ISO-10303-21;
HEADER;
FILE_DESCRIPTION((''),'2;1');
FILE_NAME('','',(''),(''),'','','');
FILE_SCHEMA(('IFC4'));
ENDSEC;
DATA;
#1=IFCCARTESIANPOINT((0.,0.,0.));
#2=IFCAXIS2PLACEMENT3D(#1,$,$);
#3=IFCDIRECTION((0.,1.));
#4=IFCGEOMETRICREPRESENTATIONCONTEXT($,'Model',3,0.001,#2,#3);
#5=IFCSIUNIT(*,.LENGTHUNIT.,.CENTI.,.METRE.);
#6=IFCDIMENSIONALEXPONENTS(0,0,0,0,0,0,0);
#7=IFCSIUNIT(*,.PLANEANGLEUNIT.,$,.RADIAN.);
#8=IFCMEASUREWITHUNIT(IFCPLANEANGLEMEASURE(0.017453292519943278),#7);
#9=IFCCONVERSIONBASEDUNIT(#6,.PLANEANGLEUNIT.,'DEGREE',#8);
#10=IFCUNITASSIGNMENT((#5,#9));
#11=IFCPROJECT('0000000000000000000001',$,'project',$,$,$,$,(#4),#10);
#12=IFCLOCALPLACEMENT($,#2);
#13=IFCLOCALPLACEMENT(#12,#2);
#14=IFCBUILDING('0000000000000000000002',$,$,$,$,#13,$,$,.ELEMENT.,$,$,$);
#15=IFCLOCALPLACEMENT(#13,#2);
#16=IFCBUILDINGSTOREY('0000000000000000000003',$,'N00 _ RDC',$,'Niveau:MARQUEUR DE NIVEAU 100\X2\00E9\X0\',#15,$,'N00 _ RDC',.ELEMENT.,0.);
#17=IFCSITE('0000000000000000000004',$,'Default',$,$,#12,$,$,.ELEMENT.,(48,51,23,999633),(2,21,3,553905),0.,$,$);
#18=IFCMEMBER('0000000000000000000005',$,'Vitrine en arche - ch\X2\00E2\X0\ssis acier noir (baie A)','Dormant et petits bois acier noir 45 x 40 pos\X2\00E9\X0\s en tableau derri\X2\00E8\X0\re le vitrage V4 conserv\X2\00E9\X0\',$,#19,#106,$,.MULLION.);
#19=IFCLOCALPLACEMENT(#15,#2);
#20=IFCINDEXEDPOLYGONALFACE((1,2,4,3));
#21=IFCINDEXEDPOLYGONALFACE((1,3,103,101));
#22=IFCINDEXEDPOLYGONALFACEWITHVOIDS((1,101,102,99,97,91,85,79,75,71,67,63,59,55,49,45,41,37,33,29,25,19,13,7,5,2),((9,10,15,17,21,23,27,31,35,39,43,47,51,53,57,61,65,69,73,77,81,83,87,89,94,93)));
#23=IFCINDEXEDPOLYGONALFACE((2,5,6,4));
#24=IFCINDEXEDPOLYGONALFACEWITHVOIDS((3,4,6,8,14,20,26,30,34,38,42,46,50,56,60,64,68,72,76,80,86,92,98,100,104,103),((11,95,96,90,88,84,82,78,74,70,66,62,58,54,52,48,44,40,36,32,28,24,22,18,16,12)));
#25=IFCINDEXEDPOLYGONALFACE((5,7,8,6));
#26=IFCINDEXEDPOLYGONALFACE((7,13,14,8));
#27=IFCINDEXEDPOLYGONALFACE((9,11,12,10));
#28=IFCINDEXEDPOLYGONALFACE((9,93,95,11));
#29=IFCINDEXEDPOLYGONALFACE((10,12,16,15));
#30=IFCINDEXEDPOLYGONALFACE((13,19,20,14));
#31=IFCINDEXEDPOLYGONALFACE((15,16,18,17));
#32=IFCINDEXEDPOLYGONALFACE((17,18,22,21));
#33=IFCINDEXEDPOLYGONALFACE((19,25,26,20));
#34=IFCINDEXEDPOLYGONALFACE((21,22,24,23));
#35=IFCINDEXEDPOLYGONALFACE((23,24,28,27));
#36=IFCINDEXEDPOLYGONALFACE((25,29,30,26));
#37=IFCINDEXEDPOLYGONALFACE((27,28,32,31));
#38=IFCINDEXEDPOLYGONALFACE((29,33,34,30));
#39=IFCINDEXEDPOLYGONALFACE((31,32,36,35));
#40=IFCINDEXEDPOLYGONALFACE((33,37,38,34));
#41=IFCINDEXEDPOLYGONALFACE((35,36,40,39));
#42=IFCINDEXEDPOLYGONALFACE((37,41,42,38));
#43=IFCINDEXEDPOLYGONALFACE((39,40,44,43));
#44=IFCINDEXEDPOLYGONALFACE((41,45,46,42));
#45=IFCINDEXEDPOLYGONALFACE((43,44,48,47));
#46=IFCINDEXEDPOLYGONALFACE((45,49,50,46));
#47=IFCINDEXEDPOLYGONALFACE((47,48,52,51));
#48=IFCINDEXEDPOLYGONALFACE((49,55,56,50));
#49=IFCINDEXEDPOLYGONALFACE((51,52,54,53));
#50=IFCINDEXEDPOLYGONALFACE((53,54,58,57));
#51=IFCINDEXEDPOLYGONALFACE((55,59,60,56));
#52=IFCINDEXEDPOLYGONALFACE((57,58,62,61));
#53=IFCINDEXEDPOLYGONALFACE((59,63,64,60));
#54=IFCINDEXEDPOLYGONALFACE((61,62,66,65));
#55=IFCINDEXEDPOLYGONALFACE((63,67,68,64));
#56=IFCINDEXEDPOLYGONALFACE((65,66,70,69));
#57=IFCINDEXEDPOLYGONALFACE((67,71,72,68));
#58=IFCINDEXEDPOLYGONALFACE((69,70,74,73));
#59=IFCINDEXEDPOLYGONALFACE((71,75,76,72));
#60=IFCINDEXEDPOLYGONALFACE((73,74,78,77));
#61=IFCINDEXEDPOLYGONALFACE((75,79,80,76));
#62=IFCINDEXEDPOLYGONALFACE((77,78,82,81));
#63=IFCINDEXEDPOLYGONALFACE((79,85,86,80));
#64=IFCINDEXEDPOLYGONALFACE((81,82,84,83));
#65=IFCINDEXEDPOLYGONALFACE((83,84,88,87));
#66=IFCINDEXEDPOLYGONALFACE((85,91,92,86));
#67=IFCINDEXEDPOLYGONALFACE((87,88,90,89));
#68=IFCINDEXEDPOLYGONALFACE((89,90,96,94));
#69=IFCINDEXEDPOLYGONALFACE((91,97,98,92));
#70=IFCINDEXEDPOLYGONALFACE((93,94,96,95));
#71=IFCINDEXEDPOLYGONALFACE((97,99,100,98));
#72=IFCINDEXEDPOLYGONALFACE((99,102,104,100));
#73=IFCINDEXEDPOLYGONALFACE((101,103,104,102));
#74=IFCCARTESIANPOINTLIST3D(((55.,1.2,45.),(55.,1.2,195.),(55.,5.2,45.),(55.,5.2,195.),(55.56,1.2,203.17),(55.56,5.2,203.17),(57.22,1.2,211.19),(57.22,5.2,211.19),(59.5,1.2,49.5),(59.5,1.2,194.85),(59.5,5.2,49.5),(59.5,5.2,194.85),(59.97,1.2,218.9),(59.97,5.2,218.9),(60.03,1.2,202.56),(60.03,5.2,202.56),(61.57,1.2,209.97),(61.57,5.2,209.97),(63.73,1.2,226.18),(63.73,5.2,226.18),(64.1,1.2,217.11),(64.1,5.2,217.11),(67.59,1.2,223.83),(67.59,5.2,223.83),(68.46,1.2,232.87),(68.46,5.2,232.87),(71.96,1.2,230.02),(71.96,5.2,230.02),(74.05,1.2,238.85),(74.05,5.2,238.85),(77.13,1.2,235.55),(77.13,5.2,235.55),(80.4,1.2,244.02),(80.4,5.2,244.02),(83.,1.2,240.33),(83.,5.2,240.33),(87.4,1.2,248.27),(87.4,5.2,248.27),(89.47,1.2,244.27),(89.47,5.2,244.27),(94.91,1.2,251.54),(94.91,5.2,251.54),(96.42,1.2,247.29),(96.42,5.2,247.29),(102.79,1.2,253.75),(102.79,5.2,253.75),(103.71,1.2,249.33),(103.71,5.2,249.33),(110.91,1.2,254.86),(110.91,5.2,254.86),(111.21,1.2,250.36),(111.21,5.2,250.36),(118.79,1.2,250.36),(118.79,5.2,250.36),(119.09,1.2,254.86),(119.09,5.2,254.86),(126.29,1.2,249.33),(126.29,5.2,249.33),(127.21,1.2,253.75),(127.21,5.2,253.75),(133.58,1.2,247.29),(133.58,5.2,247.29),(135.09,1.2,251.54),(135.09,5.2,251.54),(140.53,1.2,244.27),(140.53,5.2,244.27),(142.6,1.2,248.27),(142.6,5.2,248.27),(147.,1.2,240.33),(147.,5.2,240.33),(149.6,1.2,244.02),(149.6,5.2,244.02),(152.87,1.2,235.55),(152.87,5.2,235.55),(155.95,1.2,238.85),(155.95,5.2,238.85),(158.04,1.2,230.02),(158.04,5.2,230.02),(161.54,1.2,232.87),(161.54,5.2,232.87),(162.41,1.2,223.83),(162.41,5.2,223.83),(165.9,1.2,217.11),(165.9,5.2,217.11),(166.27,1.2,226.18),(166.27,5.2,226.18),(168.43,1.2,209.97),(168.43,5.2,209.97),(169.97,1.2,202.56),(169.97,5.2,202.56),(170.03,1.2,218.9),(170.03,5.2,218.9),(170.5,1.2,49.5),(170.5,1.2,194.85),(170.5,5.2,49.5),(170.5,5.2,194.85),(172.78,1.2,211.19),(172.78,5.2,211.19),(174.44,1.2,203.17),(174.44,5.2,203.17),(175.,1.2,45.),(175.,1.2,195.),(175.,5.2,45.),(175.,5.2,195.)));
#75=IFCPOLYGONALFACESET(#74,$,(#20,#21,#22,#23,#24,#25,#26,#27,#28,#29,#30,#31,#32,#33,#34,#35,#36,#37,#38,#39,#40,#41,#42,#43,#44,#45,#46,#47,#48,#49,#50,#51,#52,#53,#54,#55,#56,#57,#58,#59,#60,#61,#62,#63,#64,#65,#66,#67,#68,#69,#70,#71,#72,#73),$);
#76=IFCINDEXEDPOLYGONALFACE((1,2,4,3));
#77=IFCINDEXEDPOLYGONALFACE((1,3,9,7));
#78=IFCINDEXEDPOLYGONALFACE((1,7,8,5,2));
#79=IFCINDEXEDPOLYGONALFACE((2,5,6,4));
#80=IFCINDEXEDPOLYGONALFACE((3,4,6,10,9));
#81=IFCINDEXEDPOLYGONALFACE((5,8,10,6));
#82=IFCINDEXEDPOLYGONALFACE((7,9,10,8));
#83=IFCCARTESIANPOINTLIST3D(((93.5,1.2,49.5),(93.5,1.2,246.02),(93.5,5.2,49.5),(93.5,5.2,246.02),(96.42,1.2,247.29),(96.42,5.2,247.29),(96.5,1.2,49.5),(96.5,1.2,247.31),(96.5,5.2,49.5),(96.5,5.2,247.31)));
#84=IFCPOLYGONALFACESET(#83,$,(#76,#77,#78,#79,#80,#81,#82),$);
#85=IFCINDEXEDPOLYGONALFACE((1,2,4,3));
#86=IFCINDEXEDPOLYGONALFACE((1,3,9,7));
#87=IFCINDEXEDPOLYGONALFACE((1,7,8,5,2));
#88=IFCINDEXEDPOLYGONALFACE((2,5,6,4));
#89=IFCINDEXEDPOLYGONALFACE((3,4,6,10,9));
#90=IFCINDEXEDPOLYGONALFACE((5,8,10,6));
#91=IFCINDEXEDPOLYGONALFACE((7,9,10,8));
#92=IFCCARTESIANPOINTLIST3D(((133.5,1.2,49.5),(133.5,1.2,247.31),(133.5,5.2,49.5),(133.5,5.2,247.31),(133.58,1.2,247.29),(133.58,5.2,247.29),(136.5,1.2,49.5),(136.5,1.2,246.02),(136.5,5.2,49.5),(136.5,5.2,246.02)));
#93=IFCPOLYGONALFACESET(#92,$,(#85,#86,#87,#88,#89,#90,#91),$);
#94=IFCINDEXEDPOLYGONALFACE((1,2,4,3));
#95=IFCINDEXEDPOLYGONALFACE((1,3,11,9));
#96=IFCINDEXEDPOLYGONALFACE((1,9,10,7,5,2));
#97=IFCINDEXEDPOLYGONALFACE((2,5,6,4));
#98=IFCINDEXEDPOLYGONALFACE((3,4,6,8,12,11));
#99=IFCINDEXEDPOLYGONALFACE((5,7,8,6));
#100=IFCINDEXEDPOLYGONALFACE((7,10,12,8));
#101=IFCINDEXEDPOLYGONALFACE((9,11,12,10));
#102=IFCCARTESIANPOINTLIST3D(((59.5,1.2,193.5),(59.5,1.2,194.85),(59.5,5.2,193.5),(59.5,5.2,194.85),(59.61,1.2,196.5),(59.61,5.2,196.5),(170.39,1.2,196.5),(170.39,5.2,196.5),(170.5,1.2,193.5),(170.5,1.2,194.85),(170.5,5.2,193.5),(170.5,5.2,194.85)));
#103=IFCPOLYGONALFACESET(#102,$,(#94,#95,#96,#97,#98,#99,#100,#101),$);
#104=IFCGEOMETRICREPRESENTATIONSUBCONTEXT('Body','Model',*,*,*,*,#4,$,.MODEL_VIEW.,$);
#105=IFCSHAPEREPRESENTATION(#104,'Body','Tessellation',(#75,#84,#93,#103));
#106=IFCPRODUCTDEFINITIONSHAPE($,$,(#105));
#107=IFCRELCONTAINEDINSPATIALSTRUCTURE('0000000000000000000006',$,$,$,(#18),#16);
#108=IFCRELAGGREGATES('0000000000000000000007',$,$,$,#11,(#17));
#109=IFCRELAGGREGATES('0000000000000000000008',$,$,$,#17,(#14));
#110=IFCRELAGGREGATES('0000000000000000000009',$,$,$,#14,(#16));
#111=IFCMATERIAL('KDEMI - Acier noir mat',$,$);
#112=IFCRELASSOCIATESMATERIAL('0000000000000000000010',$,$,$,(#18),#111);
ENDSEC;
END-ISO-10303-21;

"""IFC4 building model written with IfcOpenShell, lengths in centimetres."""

from ifc_helpers import new_model, entity, si_unit, converted_unit, direction, frame, origin, origin_with_axes, place, context, subcontext, project, spatial, polyline, outline, extrude, material, element, save


model = new_model("IFC4")

# Units and contexts
model_context = context("Model", 3, precision=0.001, world=origin(), true_north=direction((0.0, 1.0)))
body_context = subcontext(model_context, "Body", "Model", "MODEL_VIEW")
ifc_project = project(units=[si_unit("LENGTHUNIT", "METRE", prefix="CENTI"), converted_unit("PLANEANGLEUNIT", "DEGREE", entity("IfcPlaneAngleMeasure", 0.017453292519943278), si_unit("PLANEANGLEUNIT", "RADIAN"), dimensions=[0, 0, 0, 0, 0, 0, 0])], contexts=[model_context])

# Site, building, storey
site_placement = place(None, origin())
site = spatial("IfcSite", under=ifc_project, at=site_placement, Name="Default", CompositionType="ELEMENT", RefLatitude=(48, 51, 23, 999633), RefLongitude=(2, 21, 3, 553905), RefElevation=0.0)
building_placement = place(site_placement, origin())
building = spatial("IfcBuilding", under=site, at=building_placement, CompositionType="ELEMENT")
storey_placement = place(building_placement, origin())
storey = spatial("IfcBuildingStorey", under=building, at=storey_placement, Name="N00 _ RDC", ObjectType="Niveau:MARQUEUR DE NIVEAU 100é", LongName="N00 _ RDC", CompositionType="ELEMENT", Elevation=0.0)

# Member
ifc_material_1 = material(Name="KDEMI - Acier noir mat")
member_1_placement = place(storey_placement, origin_with_axes())
element("IfcMember", 1, at=member_1_placement, inside=storey, material=ifc_material_1, Name="Vitrine en arche - châssis acier noir (baie A)", Description="Dormant et petits bois acier noir 45 x 40 posés en tableau derrière le vitrage V4 conservé", PredefinedType="MULLION", context=body_context, shape_type="SweptSolid", body=[
    extrude(outline(polyline([(55.0, 195.0), (55.56, 203.17), (57.22, 211.19), (59.97, 218.9), (63.73, 226.18), (68.46, 232.87), (74.05, 238.85), (80.4, 244.02), (87.4, 248.27), (94.91, 251.54), (102.79, 253.75), (110.91, 254.86), (119.09, 254.86), (127.21, 253.75), (135.09, 251.54), (142.6, 248.27), (149.6, 244.02), (155.95, 238.85), (161.54, 232.87), (166.27, 226.18), (170.03, 218.9), (172.78, 211.19), (174.44, 203.17), (175.0, 195.0), (175.0, 45.0), (55.0, 45.0), (55.0, 195.0)]), holes=[polyline([(170.5, 49.5), (170.5, 194.85), (169.97, 202.56), (168.43, 209.97), (165.9, 217.11), (162.41, 223.83), (158.04, 230.02), (152.87, 235.55), (147.0, 240.33), (140.53, 244.27), (133.58, 247.29), (126.29, 249.33), (118.79, 250.36), (111.21, 250.36), (103.71, 249.33), (96.42, 247.29), (89.47, 244.27), (83.0, 240.33), (77.13, 235.55), (71.96, 230.02), (67.59, 223.83), (64.1, 217.11), (61.57, 209.97), (60.03, 202.56), (59.5, 194.85), (59.5, 49.5), (170.5, 49.5)])]), frame((0.0, 5.2, 0.0), z_axis=(0.0, -1.0, 0.0), x_axis=(1.0, 0.0, 0.0)), (0.0, 0.0, 1.0), 4.0),
    extrude(outline(polyline([(96.5, 49.5), (93.5, 49.5), (93.5, 246.02), (96.42, 247.29), (96.5, 247.31), (96.5, 49.5)])), frame((0.0, 5.2, 0.0), z_axis=(0.0, -1.0, 0.0), x_axis=(1.0, 0.0, 0.0)), (0.0, 0.0, 1.0), 4.0),
    extrude(outline(polyline([(136.5, 49.5), (133.5, 49.5), (133.5, 247.31), (133.58, 247.29), (136.5, 246.02), (136.5, 49.5)])), frame((0.0, 5.2, 0.0), z_axis=(0.0, -1.0, 0.0), x_axis=(1.0, 0.0, 0.0)), (0.0, 0.0, 1.0), 4.0),
    extrude(outline(polyline([(170.39, 196.5), (170.5, 194.85), (170.5, 193.5), (59.5, 193.5), (59.5, 194.85), (59.61, 196.5), (170.39, 196.5)])), frame((0.0, 5.2, 0.0), z_axis=(0.0, -1.0, 0.0), x_axis=(1.0, 0.0, 0.0)), (0.0, 0.0, 1.0), 4.0),
])

save(model, "model.ifc")
